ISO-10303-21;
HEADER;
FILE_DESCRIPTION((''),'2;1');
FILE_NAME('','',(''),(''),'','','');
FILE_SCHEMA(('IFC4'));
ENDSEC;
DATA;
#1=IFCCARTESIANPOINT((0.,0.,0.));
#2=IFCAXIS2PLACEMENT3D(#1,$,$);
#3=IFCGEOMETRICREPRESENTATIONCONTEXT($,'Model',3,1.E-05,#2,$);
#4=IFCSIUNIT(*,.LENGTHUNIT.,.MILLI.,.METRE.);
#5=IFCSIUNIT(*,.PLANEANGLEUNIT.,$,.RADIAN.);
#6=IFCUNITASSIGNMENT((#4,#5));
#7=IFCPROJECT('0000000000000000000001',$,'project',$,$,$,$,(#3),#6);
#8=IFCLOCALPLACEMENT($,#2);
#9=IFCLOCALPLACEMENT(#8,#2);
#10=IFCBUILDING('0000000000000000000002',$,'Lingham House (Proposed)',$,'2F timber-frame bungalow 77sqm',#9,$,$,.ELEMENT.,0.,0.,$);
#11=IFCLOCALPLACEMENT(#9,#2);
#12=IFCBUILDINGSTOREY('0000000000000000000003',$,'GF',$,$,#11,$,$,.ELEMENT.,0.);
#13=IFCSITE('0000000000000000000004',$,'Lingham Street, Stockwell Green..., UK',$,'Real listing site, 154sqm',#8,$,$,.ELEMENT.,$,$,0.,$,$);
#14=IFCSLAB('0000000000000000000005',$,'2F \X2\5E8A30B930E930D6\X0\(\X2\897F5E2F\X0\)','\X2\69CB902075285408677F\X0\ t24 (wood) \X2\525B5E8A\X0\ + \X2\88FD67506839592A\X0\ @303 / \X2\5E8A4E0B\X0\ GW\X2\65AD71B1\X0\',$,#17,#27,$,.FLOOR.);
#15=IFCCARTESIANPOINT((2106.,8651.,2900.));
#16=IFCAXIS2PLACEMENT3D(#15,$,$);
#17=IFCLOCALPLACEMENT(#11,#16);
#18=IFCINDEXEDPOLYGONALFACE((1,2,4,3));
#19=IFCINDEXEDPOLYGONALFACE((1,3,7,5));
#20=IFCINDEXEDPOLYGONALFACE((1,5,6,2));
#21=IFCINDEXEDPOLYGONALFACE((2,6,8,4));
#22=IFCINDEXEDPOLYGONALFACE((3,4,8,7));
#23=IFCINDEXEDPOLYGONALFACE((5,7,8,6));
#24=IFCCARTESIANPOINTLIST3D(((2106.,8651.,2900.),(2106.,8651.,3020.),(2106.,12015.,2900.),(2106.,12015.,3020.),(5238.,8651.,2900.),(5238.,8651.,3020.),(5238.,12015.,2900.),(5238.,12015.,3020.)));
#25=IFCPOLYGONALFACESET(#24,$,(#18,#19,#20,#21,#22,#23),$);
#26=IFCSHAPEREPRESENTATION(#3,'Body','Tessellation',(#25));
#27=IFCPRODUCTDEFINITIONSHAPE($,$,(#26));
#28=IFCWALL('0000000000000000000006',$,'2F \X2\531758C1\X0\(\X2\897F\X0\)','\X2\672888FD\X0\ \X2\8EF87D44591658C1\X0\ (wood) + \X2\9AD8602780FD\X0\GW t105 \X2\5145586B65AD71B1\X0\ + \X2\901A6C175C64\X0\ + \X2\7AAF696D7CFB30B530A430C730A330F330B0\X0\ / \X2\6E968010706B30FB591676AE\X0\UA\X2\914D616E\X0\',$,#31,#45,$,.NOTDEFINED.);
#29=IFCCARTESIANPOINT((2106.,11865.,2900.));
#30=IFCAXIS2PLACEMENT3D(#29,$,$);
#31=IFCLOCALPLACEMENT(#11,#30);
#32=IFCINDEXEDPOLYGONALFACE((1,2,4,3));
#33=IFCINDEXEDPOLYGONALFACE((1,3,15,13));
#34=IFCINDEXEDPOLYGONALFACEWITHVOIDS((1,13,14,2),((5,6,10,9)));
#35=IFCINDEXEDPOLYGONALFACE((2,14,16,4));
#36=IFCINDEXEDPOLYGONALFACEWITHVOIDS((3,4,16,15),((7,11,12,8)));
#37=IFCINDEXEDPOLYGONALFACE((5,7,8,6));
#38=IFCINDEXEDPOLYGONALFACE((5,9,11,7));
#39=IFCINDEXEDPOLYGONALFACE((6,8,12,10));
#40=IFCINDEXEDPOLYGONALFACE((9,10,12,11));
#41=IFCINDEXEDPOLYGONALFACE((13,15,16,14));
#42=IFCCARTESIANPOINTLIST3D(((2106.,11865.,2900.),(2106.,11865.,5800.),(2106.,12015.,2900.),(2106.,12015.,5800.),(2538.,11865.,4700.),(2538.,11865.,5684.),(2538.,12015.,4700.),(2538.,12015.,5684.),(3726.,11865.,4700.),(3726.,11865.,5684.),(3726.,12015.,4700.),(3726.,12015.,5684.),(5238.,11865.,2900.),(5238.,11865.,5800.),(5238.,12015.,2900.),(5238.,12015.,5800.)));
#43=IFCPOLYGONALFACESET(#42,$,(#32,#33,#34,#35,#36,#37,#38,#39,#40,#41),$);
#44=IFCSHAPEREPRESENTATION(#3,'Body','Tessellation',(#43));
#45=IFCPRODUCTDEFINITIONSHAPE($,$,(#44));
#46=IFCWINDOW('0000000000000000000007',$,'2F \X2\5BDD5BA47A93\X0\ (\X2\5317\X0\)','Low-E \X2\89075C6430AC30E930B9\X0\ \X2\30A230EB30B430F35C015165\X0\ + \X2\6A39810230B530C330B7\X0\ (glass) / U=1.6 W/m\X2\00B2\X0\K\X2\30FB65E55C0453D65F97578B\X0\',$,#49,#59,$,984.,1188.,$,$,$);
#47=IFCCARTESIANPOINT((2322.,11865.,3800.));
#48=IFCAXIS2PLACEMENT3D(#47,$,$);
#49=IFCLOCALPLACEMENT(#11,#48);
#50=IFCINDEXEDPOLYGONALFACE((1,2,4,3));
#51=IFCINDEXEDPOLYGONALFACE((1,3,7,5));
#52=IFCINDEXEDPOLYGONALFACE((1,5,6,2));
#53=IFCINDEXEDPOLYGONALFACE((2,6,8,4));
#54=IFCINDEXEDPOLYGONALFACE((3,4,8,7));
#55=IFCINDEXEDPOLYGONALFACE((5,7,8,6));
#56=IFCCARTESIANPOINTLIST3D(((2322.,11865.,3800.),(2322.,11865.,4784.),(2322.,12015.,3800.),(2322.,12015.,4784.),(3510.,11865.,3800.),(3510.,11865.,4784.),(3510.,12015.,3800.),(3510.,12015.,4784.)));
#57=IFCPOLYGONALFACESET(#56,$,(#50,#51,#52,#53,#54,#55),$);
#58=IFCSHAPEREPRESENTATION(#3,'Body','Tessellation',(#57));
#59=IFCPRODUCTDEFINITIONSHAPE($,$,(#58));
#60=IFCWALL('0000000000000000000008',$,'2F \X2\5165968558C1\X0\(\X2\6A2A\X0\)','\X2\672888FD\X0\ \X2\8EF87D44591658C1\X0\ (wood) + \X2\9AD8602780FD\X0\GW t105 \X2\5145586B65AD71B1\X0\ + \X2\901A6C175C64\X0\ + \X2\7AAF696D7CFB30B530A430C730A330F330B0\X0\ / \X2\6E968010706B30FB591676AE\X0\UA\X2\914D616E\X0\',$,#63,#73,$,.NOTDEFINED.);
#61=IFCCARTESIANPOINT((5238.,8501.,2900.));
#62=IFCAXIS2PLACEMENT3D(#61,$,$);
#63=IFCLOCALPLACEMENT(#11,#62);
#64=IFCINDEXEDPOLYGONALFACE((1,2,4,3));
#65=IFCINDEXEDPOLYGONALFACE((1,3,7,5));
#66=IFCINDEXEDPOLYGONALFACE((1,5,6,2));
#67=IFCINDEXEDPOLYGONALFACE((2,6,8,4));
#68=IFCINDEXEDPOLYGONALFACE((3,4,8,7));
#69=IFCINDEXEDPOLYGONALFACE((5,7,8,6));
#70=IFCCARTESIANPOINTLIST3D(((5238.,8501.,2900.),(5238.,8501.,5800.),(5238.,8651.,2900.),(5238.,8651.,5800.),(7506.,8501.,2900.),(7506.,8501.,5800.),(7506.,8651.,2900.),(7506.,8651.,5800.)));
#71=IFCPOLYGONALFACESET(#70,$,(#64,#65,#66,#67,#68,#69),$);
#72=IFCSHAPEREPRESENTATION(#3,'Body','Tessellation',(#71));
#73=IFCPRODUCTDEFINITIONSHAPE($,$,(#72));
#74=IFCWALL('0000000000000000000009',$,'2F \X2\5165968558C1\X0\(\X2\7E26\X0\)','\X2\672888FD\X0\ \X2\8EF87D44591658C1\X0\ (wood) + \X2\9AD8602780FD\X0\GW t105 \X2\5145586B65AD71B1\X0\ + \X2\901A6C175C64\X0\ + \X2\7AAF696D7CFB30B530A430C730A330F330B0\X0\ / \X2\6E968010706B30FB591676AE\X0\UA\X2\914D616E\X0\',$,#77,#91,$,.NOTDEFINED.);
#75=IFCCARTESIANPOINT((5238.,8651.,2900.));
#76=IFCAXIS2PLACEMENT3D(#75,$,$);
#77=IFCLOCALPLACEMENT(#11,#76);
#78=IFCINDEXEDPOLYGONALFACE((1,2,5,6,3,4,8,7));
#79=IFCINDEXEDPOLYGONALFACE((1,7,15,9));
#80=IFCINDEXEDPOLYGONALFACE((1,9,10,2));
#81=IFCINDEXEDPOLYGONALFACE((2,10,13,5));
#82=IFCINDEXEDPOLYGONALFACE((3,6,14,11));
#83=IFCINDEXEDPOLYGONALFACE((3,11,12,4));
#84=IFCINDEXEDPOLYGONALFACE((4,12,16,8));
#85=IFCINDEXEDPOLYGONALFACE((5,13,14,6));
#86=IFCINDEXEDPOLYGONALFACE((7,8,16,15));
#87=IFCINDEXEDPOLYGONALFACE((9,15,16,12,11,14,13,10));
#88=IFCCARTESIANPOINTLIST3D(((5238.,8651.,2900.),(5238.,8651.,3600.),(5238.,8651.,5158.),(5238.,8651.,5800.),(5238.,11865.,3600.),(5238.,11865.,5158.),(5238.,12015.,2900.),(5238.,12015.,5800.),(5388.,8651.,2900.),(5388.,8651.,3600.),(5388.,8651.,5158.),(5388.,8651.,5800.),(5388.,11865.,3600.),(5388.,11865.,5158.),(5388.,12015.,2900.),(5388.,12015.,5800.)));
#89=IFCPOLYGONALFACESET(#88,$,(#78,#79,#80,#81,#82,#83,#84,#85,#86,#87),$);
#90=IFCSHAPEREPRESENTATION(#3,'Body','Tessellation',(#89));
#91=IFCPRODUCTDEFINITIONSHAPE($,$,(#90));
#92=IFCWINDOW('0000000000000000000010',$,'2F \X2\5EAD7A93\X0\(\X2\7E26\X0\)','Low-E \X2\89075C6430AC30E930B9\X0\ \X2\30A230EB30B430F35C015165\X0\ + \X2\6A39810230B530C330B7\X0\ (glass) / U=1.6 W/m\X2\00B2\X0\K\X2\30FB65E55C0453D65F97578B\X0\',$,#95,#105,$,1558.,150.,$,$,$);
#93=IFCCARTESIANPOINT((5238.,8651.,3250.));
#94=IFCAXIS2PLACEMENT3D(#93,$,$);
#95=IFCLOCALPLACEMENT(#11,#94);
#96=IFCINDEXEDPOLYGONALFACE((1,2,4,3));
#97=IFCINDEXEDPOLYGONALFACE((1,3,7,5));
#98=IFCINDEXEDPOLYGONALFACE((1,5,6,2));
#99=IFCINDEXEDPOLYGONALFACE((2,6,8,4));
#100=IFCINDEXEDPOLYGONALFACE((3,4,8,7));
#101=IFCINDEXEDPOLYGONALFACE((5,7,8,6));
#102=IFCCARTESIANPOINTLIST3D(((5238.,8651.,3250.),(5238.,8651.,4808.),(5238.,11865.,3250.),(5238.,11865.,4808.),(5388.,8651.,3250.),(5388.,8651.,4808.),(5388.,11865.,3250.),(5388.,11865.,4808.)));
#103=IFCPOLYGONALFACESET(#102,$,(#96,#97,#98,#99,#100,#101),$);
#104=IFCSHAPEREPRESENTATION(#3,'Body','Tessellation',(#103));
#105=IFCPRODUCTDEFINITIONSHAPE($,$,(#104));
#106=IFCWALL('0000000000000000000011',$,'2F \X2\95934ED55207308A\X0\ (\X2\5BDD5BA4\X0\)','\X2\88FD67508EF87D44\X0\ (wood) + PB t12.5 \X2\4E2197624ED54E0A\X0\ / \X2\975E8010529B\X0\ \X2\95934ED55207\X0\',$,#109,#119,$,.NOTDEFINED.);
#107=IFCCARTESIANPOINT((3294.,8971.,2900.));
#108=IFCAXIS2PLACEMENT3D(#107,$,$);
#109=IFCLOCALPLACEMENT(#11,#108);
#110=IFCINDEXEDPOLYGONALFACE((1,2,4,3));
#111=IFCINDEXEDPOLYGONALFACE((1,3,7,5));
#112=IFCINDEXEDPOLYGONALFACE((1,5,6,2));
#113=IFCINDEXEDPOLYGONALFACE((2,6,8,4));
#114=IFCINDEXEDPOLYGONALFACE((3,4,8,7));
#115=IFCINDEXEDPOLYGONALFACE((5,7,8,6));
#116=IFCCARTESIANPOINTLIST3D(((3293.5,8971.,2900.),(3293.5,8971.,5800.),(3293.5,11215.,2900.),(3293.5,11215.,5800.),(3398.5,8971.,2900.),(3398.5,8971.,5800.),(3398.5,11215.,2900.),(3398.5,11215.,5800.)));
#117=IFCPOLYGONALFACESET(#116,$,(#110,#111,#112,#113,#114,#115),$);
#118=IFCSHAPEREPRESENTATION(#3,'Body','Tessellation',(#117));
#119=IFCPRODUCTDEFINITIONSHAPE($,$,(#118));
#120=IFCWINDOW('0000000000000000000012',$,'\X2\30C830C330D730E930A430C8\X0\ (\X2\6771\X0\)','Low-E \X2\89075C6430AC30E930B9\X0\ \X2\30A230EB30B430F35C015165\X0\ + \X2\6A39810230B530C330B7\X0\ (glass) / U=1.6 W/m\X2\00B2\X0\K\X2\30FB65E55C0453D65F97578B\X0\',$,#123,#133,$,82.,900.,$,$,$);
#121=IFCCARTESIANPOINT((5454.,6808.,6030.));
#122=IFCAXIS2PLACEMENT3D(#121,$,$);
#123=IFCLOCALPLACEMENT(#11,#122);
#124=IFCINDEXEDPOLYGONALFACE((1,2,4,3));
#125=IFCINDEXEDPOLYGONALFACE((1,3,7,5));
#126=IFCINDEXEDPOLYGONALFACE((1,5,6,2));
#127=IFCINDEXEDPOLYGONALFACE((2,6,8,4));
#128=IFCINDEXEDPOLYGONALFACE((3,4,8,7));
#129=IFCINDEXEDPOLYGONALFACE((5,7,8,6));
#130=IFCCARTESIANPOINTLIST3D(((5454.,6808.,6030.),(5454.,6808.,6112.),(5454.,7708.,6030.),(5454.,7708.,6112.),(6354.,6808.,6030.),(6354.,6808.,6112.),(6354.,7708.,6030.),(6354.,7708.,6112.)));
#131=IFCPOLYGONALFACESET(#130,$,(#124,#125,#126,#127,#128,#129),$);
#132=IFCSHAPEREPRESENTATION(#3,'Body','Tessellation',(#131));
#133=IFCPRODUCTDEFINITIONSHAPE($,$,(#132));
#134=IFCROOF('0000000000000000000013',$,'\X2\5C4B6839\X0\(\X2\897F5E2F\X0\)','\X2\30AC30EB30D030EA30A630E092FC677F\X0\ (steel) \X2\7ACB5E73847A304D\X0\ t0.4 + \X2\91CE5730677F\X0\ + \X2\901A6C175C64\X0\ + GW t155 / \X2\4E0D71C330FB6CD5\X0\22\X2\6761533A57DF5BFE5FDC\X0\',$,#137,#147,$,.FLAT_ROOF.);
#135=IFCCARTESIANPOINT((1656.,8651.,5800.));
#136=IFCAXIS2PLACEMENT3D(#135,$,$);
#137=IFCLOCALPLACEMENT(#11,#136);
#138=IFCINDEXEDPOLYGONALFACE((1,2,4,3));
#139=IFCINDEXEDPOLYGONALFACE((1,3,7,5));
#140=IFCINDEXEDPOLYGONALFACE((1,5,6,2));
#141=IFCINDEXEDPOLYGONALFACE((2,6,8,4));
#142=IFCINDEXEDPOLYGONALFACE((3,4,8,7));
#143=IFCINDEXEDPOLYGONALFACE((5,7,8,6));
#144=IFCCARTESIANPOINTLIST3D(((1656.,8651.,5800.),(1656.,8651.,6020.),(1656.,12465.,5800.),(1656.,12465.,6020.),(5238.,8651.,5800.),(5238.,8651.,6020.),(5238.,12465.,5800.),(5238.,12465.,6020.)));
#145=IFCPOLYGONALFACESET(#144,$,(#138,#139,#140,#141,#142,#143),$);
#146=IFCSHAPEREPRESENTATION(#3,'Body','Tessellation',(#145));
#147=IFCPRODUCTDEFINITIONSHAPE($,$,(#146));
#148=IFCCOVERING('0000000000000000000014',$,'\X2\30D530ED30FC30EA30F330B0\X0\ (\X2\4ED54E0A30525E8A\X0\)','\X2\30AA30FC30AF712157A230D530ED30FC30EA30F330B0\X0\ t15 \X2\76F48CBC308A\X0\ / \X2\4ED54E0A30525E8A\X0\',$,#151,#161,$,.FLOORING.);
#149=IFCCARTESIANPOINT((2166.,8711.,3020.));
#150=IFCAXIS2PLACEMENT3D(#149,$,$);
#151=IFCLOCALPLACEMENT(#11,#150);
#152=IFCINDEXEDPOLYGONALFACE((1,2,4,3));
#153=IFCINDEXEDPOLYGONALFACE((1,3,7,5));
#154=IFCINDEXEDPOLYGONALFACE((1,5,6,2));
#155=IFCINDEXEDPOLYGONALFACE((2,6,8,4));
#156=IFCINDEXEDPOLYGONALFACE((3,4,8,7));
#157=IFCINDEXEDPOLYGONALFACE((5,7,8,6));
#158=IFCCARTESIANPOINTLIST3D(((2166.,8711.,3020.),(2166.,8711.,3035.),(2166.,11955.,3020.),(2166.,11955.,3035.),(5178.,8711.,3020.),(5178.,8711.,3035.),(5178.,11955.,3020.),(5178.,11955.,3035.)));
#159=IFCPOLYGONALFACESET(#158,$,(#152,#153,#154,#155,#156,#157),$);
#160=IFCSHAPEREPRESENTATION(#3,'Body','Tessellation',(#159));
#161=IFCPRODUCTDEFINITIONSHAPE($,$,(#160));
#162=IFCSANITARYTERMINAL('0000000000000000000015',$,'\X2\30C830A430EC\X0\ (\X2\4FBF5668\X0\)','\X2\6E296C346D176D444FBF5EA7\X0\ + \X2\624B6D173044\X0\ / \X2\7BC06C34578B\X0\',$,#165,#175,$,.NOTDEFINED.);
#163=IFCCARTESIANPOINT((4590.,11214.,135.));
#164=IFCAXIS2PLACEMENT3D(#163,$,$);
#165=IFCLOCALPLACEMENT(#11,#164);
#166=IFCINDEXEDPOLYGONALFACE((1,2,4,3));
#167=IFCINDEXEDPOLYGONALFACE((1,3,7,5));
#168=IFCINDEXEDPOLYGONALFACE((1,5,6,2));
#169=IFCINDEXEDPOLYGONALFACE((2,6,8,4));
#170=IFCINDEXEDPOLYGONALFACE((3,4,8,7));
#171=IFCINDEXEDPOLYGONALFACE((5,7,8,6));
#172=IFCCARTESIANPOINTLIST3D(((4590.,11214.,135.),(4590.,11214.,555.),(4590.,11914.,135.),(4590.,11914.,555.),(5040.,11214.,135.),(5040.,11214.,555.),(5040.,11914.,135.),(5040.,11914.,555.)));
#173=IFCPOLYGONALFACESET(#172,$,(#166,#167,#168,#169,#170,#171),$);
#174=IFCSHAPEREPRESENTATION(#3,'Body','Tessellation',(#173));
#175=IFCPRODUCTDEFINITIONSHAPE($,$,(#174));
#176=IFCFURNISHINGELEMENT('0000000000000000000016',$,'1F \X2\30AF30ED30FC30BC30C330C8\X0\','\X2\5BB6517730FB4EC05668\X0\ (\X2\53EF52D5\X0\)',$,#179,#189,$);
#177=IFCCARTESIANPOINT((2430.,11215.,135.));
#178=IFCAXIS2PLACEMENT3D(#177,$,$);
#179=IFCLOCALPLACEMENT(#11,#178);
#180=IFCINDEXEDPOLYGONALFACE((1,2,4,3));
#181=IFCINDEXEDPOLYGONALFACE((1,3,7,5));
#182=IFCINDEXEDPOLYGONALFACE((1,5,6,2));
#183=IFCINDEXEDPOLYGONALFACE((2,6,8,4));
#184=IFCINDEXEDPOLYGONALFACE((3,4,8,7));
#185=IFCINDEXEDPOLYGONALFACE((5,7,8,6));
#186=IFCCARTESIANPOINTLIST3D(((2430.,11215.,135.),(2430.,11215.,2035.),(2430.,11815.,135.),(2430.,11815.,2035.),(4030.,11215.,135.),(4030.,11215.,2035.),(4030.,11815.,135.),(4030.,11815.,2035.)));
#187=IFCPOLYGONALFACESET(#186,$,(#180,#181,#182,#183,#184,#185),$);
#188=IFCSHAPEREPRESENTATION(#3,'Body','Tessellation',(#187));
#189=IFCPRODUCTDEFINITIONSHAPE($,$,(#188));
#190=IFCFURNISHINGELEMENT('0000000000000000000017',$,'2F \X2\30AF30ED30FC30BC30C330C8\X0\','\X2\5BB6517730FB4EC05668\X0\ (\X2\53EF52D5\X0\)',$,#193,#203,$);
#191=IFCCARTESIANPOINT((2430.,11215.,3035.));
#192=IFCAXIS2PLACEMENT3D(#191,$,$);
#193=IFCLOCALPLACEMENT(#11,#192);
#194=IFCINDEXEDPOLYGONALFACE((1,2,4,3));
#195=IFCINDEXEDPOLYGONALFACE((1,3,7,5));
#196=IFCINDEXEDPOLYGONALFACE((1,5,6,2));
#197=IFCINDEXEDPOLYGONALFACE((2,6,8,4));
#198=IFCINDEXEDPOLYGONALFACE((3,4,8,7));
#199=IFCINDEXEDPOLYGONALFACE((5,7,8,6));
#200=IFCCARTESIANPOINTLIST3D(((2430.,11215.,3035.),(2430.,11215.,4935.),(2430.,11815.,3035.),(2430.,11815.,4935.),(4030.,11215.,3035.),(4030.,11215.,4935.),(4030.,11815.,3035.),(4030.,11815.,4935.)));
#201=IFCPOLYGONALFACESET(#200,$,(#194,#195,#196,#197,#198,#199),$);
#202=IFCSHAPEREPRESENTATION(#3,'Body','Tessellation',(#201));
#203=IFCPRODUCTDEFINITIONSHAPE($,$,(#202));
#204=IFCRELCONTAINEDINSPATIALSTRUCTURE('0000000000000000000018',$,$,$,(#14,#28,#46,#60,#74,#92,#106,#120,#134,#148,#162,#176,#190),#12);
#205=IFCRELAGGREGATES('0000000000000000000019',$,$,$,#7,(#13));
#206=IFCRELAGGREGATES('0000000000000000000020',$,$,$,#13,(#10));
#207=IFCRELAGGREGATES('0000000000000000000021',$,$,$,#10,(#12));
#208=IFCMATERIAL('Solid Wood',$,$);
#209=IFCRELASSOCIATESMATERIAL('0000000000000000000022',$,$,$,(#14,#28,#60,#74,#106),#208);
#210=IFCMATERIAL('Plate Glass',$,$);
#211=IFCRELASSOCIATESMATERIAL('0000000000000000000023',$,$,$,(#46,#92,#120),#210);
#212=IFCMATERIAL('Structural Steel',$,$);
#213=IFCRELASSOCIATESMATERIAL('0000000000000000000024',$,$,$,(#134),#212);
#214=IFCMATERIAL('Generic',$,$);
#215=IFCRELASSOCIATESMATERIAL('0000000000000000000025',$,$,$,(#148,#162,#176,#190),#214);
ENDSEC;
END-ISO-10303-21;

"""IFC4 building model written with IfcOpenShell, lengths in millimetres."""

from ifc_helpers import new_model, si_unit, frame, frame_2d, origin, place, context, project, spatial, rectangle, extrude, material, element, fill, save


model = new_model("IFC4")

# Units and contexts
model_context = context("Model", 3, precision=1e-05, world=origin())
ifc_project = project(units=[si_unit("LENGTHUNIT", "METRE", prefix="MILLI"), si_unit("PLANEANGLEUNIT", "RADIAN")], contexts=[model_context])

# Site, building, storey
site_placement = place(None, origin())
site = spatial("IfcSite", under=ifc_project, at=site_placement, Name="Lingham Street, Stockwell Green..., UK", ObjectType="Real listing site, 154sqm", CompositionType="ELEMENT", RefElevation=0.0)
building_placement = place(site_placement, origin())
building = spatial("IfcBuilding", under=site, at=building_placement, Name="Lingham House (Proposed)", ObjectType="2F timber-frame bungalow 77sqm", CompositionType="ELEMENT", ElevationOfRefHeight=0.0, ElevationOfTerrain=0.0)
storey_placement = place(building_placement, origin())
storey = spatial("IfcBuildingStorey", under=building, at=storey_placement, Name="GF", CompositionType="ELEMENT", Elevation=0.0)

# Slab
ifc_material_1 = material(Name="Solid Wood")
slab_placement = place(storey_placement, frame((2106.0, 8651.0, 2900.0)))
element("IfcSlab", 1, at=slab_placement, inside=storey, material=ifc_material_1, Name="2F 床スラブ(西帯)", Description="構造用合板 t24 (wood) 剛床 + 製材根太 @303 / 床下 GW断熱", PredefinedType="FLOOR", context=model_context, shape_type="SweptSolid", body=[
    extrude(rectangle(XDim=3132.0, YDim=3364.0, at=frame_2d((1566.0, 1682.0))), frame((2106.0, 8651.0, 2900.0)), (0.0, 0.0, 1.0), 120.0),
])

# Wall, opening, window
wall_1_placement = place(storey_placement, frame((2106.0, 11865.0, 2900.0)))
wall_1 = element("IfcWall", 2, at=wall_1_placement, inside=storey, material=ifc_material_1, Name="2F 北壁(西)", Description="木製 軸組外壁 (wood) + 高性能GW t105 充填断熱 + 通気層 + 窯業系サイディング / 準耐火・外皮UA配慮", PredefinedType="NOTDEFINED", context=model_context, shape_type="SweptSolid", body=[
    extrude(rectangle(XDim=3132.0, YDim=150.0, at=frame_2d((1566.0, 75.0))), frame((2106.0, 11865.0, 2900.0)), (0.0, 0.0, 1.0), 2900.0),
])
opening_1_placement = place(storey_placement, frame((2322.0, 11865.0, 3800.0)))
opening_1 = element("IfcOpeningElement", 3, at=opening_1_placement, cuts=wall_1, PredefinedType="NOTDEFINED", context=model_context, shape_type="SweptSolid", body=[
    extrude(rectangle(XDim=1188.0, YDim=150.0, at=frame_2d((594.0, 75.0))), frame((2322.0, 11865.0, 3800.0)), (0.0, 0.0, 1.0), 984.0),
])
ifc_material_2 = material(Name="Plate Glass")
window_1_placement = place(storey_placement, frame((2322.0, 11865.0, 3800.0)))
window_1 = element("IfcWindow", 4, at=window_1_placement, inside=storey, material=ifc_material_2, Name="2F 寝室窓 (北)", Description="Low-E 複層ガラス アルゴン封入 + 樹脂サッシ (glass) / U=1.6 W/m²K・日射取得型", OverallHeight=984.0, OverallWidth=1188.0, context=model_context, shape_type="SweptSolid", body=[
    extrude(rectangle(XDim=1188.0, YDim=150.0, at=frame_2d((594.0, 75.0))), frame((2322.0, 11865.0, 3800.0)), (0.0, 0.0, 1.0), 984.0),
])
fill(opening_1, window_1)

# Wall
wall_2_placement = place(storey_placement, frame((5238.0, 8501.0, 2900.0)))
element("IfcWall", 5, at=wall_2_placement, inside=storey, material=ifc_material_1, Name="2F 入隅壁(横)", Description="木製 軸組外壁 (wood) + 高性能GW t105 充填断熱 + 通気層 + 窯業系サイディング / 準耐火・外皮UA配慮", PredefinedType="NOTDEFINED", context=model_context, shape_type="SweptSolid", body=[
    extrude(rectangle(XDim=2268.0, YDim=150.0, at=frame_2d((1134.0, 75.0))), frame((5238.0, 8501.0, 2900.0)), (0.0, 0.0, 1.0), 2900.0),
])

# Wall, opening, window
wall_3_placement = place(storey_placement, frame((5238.0, 8651.0, 2900.0)))
wall_3 = element("IfcWall", 6, at=wall_3_placement, inside=storey, material=ifc_material_1, Name="2F 入隅壁(縦)", Description="木製 軸組外壁 (wood) + 高性能GW t105 充填断熱 + 通気層 + 窯業系サイディング / 準耐火・外皮UA配慮", PredefinedType="NOTDEFINED", context=model_context, shape_type="SweptSolid", body=[
    extrude(rectangle(XDim=150.0, YDim=3364.0, at=frame_2d((75.0, 1682.0))), frame((5238.0, 8651.0, 2900.0)), (0.0, 0.0, 1.0), 2900.0),
])
opening_2_placement = place(storey_placement, frame((5238.0, 8651.0, 3250.0)))
opening_2 = element("IfcOpeningElement", 7, at=opening_2_placement, cuts=wall_3, PredefinedType="NOTDEFINED", context=model_context, shape_type="SweptSolid", body=[
    extrude(rectangle(XDim=150.0, YDim=3214.0, at=frame_2d((75.0, 1607.0))), frame((5238.0, 8651.0, 3250.0)), (0.0, 0.0, 1.0), 1558.0),
])
window_2_placement = place(storey_placement, frame((5238.0, 8651.0, 3250.0)))
window_2 = element("IfcWindow", 8, at=window_2_placement, inside=storey, material=ifc_material_2, Name="2F 庭窓(縦)", Description="Low-E 複層ガラス アルゴン封入 + 樹脂サッシ (glass) / U=1.6 W/m²K・日射取得型", OverallHeight=1558.0, OverallWidth=150.0, context=model_context, shape_type="SweptSolid", body=[
    extrude(rectangle(XDim=150.0, YDim=3214.0, at=frame_2d((75.0, 1607.0))), frame((5238.0, 8651.0, 3250.0)), (0.0, 0.0, 1.0), 1558.0),
])
fill(opening_2, window_2)

# Wall
wall_4_placement = place(storey_placement, frame((3294.0, 8971.0, 2900.0)))
element("IfcWall", 9, at=wall_4_placement, inside=storey, material=ifc_material_1, Name="2F 間仕切り (寝室)", Description="製材軸組 (wood) + PB t12.5 両面仕上 / 非耐力 間仕切", PredefinedType="NOTDEFINED", context=model_context, shape_type="SweptSolid", body=[
    extrude(rectangle(XDim=105.0, YDim=2244.0, at=frame_2d((52.0, 1122.0))), frame((3294.0, 8971.0, 2900.0)), (0.0, 0.0, 1.0), 2900.0),
])

# Window
window_3_placement = place(storey_placement, frame((5454.0, 6808.0, 6030.0)))
element("IfcWindow", 10, at=window_3_placement, inside=storey, material=ifc_material_2, Name="トップライト (東)", Description="Low-E 複層ガラス アルゴン封入 + 樹脂サッシ (glass) / U=1.6 W/m²K・日射取得型", OverallHeight=82.0, OverallWidth=900.0, context=model_context, shape_type="SweptSolid", body=[
    extrude(rectangle(XDim=900.0, YDim=900.0, at=frame_2d((450.0, 450.0))), frame((5454.0, 6808.0, 6030.0)), (0.0, 0.0, 1.0), 82.0),
])

# Roof
ifc_material_3 = material(Name="Structural Steel")
for number, where, name in (
    (11, (1656.0, 8651.0, 5800.0), "屋根(西帯)"),
):
    element("IfcRoof", number, at=place(storey_placement, frame(where)), inside=storey, material=ifc_material_3, Name=name, Description="ガルバリウム鋼板 (steel) 立平葺き t0.4 + 野地板 + 通気層 + GW t155 / 不燃・法22条区域対応", PredefinedType="FLAT_ROOF", context=model_context, shape_type="SweptSolid", body=[
        extrude(rectangle(XDim=3582.0, YDim=3814.0, at=frame_2d((1791.0, 1907.0))), frame((1656.0, 8651.0, 5800.0)), (0.0, 0.0, 1.0), 220.0),
    ])

# Covering
ifc_material_4 = material(Name="Generic")
covering_placement = place(storey_placement, frame((2166.0, 8711.0, 3020.0)))
element("IfcCovering", 12, at=covering_placement, inside=storey, material=ifc_material_4, Name="フローリング (仕上げ床)", Description="オーク無垢フローリング t15 直貼り / 仕上げ床", PredefinedType="FLOORING", context=model_context, shape_type="SweptSolid", body=[
    extrude(rectangle(XDim=3012.0, YDim=3244.0, at=frame_2d((1506.0, 1622.0))), frame((2166.0, 8711.0, 3020.0)), (0.0, 0.0, 1.0), 15.0),
])

# Sanitary terminal
sanitary_terminal_placement = place(storey_placement, frame((4590.0, 11214.0, 135.0)))
element("IfcSanitaryTerminal", 13, at=sanitary_terminal_placement, inside=storey, material=ifc_material_4, Name="トイレ (便器)", Description="温水洗浄便座 + 手洗い / 節水型", PredefinedType="NOTDEFINED", context=model_context, shape_type="SweptSolid", body=[
    extrude(rectangle(XDim=450.0, YDim=700.0, at=frame_2d((225.0, 350.0))), frame((4590.0, 11214.0, 135.0)), (0.0, 0.0, 1.0), 420.0),
])

# Furnishing elements
furnishing_1_placement = place(storey_placement, frame((2430.0, 11215.0, 135.0)))
element("IfcFurnishingElement", 14, at=furnishing_1_placement, inside=storey, material=ifc_material_4, Name="1F クローゼット", Description="家具・什器 (可動)", context=model_context, shape_type="SweptSolid", body=[
    extrude(rectangle(XDim=1600.0, YDim=600.0, at=frame_2d((800.0, 300.0))), frame((2430.0, 11215.0, 135.0)), (0.0, 0.0, 1.0), 1900.0),
])
furnishing_2_placement = place(storey_placement, frame((2430.0, 11215.0, 3035.0)))
element("IfcFurnishingElement", 15, at=furnishing_2_placement, inside=storey, material=ifc_material_4, Name="2F クローゼット", Description="家具・什器 (可動)", context=model_context, shape_type="SweptSolid", body=[
    extrude(rectangle(XDim=1600.0, YDim=600.0, at=frame_2d((800.0, 300.0))), frame((2430.0, 11215.0, 3035.0)), (0.0, 0.0, 1.0), 1900.0),
])

save(model, "model.ifc")
